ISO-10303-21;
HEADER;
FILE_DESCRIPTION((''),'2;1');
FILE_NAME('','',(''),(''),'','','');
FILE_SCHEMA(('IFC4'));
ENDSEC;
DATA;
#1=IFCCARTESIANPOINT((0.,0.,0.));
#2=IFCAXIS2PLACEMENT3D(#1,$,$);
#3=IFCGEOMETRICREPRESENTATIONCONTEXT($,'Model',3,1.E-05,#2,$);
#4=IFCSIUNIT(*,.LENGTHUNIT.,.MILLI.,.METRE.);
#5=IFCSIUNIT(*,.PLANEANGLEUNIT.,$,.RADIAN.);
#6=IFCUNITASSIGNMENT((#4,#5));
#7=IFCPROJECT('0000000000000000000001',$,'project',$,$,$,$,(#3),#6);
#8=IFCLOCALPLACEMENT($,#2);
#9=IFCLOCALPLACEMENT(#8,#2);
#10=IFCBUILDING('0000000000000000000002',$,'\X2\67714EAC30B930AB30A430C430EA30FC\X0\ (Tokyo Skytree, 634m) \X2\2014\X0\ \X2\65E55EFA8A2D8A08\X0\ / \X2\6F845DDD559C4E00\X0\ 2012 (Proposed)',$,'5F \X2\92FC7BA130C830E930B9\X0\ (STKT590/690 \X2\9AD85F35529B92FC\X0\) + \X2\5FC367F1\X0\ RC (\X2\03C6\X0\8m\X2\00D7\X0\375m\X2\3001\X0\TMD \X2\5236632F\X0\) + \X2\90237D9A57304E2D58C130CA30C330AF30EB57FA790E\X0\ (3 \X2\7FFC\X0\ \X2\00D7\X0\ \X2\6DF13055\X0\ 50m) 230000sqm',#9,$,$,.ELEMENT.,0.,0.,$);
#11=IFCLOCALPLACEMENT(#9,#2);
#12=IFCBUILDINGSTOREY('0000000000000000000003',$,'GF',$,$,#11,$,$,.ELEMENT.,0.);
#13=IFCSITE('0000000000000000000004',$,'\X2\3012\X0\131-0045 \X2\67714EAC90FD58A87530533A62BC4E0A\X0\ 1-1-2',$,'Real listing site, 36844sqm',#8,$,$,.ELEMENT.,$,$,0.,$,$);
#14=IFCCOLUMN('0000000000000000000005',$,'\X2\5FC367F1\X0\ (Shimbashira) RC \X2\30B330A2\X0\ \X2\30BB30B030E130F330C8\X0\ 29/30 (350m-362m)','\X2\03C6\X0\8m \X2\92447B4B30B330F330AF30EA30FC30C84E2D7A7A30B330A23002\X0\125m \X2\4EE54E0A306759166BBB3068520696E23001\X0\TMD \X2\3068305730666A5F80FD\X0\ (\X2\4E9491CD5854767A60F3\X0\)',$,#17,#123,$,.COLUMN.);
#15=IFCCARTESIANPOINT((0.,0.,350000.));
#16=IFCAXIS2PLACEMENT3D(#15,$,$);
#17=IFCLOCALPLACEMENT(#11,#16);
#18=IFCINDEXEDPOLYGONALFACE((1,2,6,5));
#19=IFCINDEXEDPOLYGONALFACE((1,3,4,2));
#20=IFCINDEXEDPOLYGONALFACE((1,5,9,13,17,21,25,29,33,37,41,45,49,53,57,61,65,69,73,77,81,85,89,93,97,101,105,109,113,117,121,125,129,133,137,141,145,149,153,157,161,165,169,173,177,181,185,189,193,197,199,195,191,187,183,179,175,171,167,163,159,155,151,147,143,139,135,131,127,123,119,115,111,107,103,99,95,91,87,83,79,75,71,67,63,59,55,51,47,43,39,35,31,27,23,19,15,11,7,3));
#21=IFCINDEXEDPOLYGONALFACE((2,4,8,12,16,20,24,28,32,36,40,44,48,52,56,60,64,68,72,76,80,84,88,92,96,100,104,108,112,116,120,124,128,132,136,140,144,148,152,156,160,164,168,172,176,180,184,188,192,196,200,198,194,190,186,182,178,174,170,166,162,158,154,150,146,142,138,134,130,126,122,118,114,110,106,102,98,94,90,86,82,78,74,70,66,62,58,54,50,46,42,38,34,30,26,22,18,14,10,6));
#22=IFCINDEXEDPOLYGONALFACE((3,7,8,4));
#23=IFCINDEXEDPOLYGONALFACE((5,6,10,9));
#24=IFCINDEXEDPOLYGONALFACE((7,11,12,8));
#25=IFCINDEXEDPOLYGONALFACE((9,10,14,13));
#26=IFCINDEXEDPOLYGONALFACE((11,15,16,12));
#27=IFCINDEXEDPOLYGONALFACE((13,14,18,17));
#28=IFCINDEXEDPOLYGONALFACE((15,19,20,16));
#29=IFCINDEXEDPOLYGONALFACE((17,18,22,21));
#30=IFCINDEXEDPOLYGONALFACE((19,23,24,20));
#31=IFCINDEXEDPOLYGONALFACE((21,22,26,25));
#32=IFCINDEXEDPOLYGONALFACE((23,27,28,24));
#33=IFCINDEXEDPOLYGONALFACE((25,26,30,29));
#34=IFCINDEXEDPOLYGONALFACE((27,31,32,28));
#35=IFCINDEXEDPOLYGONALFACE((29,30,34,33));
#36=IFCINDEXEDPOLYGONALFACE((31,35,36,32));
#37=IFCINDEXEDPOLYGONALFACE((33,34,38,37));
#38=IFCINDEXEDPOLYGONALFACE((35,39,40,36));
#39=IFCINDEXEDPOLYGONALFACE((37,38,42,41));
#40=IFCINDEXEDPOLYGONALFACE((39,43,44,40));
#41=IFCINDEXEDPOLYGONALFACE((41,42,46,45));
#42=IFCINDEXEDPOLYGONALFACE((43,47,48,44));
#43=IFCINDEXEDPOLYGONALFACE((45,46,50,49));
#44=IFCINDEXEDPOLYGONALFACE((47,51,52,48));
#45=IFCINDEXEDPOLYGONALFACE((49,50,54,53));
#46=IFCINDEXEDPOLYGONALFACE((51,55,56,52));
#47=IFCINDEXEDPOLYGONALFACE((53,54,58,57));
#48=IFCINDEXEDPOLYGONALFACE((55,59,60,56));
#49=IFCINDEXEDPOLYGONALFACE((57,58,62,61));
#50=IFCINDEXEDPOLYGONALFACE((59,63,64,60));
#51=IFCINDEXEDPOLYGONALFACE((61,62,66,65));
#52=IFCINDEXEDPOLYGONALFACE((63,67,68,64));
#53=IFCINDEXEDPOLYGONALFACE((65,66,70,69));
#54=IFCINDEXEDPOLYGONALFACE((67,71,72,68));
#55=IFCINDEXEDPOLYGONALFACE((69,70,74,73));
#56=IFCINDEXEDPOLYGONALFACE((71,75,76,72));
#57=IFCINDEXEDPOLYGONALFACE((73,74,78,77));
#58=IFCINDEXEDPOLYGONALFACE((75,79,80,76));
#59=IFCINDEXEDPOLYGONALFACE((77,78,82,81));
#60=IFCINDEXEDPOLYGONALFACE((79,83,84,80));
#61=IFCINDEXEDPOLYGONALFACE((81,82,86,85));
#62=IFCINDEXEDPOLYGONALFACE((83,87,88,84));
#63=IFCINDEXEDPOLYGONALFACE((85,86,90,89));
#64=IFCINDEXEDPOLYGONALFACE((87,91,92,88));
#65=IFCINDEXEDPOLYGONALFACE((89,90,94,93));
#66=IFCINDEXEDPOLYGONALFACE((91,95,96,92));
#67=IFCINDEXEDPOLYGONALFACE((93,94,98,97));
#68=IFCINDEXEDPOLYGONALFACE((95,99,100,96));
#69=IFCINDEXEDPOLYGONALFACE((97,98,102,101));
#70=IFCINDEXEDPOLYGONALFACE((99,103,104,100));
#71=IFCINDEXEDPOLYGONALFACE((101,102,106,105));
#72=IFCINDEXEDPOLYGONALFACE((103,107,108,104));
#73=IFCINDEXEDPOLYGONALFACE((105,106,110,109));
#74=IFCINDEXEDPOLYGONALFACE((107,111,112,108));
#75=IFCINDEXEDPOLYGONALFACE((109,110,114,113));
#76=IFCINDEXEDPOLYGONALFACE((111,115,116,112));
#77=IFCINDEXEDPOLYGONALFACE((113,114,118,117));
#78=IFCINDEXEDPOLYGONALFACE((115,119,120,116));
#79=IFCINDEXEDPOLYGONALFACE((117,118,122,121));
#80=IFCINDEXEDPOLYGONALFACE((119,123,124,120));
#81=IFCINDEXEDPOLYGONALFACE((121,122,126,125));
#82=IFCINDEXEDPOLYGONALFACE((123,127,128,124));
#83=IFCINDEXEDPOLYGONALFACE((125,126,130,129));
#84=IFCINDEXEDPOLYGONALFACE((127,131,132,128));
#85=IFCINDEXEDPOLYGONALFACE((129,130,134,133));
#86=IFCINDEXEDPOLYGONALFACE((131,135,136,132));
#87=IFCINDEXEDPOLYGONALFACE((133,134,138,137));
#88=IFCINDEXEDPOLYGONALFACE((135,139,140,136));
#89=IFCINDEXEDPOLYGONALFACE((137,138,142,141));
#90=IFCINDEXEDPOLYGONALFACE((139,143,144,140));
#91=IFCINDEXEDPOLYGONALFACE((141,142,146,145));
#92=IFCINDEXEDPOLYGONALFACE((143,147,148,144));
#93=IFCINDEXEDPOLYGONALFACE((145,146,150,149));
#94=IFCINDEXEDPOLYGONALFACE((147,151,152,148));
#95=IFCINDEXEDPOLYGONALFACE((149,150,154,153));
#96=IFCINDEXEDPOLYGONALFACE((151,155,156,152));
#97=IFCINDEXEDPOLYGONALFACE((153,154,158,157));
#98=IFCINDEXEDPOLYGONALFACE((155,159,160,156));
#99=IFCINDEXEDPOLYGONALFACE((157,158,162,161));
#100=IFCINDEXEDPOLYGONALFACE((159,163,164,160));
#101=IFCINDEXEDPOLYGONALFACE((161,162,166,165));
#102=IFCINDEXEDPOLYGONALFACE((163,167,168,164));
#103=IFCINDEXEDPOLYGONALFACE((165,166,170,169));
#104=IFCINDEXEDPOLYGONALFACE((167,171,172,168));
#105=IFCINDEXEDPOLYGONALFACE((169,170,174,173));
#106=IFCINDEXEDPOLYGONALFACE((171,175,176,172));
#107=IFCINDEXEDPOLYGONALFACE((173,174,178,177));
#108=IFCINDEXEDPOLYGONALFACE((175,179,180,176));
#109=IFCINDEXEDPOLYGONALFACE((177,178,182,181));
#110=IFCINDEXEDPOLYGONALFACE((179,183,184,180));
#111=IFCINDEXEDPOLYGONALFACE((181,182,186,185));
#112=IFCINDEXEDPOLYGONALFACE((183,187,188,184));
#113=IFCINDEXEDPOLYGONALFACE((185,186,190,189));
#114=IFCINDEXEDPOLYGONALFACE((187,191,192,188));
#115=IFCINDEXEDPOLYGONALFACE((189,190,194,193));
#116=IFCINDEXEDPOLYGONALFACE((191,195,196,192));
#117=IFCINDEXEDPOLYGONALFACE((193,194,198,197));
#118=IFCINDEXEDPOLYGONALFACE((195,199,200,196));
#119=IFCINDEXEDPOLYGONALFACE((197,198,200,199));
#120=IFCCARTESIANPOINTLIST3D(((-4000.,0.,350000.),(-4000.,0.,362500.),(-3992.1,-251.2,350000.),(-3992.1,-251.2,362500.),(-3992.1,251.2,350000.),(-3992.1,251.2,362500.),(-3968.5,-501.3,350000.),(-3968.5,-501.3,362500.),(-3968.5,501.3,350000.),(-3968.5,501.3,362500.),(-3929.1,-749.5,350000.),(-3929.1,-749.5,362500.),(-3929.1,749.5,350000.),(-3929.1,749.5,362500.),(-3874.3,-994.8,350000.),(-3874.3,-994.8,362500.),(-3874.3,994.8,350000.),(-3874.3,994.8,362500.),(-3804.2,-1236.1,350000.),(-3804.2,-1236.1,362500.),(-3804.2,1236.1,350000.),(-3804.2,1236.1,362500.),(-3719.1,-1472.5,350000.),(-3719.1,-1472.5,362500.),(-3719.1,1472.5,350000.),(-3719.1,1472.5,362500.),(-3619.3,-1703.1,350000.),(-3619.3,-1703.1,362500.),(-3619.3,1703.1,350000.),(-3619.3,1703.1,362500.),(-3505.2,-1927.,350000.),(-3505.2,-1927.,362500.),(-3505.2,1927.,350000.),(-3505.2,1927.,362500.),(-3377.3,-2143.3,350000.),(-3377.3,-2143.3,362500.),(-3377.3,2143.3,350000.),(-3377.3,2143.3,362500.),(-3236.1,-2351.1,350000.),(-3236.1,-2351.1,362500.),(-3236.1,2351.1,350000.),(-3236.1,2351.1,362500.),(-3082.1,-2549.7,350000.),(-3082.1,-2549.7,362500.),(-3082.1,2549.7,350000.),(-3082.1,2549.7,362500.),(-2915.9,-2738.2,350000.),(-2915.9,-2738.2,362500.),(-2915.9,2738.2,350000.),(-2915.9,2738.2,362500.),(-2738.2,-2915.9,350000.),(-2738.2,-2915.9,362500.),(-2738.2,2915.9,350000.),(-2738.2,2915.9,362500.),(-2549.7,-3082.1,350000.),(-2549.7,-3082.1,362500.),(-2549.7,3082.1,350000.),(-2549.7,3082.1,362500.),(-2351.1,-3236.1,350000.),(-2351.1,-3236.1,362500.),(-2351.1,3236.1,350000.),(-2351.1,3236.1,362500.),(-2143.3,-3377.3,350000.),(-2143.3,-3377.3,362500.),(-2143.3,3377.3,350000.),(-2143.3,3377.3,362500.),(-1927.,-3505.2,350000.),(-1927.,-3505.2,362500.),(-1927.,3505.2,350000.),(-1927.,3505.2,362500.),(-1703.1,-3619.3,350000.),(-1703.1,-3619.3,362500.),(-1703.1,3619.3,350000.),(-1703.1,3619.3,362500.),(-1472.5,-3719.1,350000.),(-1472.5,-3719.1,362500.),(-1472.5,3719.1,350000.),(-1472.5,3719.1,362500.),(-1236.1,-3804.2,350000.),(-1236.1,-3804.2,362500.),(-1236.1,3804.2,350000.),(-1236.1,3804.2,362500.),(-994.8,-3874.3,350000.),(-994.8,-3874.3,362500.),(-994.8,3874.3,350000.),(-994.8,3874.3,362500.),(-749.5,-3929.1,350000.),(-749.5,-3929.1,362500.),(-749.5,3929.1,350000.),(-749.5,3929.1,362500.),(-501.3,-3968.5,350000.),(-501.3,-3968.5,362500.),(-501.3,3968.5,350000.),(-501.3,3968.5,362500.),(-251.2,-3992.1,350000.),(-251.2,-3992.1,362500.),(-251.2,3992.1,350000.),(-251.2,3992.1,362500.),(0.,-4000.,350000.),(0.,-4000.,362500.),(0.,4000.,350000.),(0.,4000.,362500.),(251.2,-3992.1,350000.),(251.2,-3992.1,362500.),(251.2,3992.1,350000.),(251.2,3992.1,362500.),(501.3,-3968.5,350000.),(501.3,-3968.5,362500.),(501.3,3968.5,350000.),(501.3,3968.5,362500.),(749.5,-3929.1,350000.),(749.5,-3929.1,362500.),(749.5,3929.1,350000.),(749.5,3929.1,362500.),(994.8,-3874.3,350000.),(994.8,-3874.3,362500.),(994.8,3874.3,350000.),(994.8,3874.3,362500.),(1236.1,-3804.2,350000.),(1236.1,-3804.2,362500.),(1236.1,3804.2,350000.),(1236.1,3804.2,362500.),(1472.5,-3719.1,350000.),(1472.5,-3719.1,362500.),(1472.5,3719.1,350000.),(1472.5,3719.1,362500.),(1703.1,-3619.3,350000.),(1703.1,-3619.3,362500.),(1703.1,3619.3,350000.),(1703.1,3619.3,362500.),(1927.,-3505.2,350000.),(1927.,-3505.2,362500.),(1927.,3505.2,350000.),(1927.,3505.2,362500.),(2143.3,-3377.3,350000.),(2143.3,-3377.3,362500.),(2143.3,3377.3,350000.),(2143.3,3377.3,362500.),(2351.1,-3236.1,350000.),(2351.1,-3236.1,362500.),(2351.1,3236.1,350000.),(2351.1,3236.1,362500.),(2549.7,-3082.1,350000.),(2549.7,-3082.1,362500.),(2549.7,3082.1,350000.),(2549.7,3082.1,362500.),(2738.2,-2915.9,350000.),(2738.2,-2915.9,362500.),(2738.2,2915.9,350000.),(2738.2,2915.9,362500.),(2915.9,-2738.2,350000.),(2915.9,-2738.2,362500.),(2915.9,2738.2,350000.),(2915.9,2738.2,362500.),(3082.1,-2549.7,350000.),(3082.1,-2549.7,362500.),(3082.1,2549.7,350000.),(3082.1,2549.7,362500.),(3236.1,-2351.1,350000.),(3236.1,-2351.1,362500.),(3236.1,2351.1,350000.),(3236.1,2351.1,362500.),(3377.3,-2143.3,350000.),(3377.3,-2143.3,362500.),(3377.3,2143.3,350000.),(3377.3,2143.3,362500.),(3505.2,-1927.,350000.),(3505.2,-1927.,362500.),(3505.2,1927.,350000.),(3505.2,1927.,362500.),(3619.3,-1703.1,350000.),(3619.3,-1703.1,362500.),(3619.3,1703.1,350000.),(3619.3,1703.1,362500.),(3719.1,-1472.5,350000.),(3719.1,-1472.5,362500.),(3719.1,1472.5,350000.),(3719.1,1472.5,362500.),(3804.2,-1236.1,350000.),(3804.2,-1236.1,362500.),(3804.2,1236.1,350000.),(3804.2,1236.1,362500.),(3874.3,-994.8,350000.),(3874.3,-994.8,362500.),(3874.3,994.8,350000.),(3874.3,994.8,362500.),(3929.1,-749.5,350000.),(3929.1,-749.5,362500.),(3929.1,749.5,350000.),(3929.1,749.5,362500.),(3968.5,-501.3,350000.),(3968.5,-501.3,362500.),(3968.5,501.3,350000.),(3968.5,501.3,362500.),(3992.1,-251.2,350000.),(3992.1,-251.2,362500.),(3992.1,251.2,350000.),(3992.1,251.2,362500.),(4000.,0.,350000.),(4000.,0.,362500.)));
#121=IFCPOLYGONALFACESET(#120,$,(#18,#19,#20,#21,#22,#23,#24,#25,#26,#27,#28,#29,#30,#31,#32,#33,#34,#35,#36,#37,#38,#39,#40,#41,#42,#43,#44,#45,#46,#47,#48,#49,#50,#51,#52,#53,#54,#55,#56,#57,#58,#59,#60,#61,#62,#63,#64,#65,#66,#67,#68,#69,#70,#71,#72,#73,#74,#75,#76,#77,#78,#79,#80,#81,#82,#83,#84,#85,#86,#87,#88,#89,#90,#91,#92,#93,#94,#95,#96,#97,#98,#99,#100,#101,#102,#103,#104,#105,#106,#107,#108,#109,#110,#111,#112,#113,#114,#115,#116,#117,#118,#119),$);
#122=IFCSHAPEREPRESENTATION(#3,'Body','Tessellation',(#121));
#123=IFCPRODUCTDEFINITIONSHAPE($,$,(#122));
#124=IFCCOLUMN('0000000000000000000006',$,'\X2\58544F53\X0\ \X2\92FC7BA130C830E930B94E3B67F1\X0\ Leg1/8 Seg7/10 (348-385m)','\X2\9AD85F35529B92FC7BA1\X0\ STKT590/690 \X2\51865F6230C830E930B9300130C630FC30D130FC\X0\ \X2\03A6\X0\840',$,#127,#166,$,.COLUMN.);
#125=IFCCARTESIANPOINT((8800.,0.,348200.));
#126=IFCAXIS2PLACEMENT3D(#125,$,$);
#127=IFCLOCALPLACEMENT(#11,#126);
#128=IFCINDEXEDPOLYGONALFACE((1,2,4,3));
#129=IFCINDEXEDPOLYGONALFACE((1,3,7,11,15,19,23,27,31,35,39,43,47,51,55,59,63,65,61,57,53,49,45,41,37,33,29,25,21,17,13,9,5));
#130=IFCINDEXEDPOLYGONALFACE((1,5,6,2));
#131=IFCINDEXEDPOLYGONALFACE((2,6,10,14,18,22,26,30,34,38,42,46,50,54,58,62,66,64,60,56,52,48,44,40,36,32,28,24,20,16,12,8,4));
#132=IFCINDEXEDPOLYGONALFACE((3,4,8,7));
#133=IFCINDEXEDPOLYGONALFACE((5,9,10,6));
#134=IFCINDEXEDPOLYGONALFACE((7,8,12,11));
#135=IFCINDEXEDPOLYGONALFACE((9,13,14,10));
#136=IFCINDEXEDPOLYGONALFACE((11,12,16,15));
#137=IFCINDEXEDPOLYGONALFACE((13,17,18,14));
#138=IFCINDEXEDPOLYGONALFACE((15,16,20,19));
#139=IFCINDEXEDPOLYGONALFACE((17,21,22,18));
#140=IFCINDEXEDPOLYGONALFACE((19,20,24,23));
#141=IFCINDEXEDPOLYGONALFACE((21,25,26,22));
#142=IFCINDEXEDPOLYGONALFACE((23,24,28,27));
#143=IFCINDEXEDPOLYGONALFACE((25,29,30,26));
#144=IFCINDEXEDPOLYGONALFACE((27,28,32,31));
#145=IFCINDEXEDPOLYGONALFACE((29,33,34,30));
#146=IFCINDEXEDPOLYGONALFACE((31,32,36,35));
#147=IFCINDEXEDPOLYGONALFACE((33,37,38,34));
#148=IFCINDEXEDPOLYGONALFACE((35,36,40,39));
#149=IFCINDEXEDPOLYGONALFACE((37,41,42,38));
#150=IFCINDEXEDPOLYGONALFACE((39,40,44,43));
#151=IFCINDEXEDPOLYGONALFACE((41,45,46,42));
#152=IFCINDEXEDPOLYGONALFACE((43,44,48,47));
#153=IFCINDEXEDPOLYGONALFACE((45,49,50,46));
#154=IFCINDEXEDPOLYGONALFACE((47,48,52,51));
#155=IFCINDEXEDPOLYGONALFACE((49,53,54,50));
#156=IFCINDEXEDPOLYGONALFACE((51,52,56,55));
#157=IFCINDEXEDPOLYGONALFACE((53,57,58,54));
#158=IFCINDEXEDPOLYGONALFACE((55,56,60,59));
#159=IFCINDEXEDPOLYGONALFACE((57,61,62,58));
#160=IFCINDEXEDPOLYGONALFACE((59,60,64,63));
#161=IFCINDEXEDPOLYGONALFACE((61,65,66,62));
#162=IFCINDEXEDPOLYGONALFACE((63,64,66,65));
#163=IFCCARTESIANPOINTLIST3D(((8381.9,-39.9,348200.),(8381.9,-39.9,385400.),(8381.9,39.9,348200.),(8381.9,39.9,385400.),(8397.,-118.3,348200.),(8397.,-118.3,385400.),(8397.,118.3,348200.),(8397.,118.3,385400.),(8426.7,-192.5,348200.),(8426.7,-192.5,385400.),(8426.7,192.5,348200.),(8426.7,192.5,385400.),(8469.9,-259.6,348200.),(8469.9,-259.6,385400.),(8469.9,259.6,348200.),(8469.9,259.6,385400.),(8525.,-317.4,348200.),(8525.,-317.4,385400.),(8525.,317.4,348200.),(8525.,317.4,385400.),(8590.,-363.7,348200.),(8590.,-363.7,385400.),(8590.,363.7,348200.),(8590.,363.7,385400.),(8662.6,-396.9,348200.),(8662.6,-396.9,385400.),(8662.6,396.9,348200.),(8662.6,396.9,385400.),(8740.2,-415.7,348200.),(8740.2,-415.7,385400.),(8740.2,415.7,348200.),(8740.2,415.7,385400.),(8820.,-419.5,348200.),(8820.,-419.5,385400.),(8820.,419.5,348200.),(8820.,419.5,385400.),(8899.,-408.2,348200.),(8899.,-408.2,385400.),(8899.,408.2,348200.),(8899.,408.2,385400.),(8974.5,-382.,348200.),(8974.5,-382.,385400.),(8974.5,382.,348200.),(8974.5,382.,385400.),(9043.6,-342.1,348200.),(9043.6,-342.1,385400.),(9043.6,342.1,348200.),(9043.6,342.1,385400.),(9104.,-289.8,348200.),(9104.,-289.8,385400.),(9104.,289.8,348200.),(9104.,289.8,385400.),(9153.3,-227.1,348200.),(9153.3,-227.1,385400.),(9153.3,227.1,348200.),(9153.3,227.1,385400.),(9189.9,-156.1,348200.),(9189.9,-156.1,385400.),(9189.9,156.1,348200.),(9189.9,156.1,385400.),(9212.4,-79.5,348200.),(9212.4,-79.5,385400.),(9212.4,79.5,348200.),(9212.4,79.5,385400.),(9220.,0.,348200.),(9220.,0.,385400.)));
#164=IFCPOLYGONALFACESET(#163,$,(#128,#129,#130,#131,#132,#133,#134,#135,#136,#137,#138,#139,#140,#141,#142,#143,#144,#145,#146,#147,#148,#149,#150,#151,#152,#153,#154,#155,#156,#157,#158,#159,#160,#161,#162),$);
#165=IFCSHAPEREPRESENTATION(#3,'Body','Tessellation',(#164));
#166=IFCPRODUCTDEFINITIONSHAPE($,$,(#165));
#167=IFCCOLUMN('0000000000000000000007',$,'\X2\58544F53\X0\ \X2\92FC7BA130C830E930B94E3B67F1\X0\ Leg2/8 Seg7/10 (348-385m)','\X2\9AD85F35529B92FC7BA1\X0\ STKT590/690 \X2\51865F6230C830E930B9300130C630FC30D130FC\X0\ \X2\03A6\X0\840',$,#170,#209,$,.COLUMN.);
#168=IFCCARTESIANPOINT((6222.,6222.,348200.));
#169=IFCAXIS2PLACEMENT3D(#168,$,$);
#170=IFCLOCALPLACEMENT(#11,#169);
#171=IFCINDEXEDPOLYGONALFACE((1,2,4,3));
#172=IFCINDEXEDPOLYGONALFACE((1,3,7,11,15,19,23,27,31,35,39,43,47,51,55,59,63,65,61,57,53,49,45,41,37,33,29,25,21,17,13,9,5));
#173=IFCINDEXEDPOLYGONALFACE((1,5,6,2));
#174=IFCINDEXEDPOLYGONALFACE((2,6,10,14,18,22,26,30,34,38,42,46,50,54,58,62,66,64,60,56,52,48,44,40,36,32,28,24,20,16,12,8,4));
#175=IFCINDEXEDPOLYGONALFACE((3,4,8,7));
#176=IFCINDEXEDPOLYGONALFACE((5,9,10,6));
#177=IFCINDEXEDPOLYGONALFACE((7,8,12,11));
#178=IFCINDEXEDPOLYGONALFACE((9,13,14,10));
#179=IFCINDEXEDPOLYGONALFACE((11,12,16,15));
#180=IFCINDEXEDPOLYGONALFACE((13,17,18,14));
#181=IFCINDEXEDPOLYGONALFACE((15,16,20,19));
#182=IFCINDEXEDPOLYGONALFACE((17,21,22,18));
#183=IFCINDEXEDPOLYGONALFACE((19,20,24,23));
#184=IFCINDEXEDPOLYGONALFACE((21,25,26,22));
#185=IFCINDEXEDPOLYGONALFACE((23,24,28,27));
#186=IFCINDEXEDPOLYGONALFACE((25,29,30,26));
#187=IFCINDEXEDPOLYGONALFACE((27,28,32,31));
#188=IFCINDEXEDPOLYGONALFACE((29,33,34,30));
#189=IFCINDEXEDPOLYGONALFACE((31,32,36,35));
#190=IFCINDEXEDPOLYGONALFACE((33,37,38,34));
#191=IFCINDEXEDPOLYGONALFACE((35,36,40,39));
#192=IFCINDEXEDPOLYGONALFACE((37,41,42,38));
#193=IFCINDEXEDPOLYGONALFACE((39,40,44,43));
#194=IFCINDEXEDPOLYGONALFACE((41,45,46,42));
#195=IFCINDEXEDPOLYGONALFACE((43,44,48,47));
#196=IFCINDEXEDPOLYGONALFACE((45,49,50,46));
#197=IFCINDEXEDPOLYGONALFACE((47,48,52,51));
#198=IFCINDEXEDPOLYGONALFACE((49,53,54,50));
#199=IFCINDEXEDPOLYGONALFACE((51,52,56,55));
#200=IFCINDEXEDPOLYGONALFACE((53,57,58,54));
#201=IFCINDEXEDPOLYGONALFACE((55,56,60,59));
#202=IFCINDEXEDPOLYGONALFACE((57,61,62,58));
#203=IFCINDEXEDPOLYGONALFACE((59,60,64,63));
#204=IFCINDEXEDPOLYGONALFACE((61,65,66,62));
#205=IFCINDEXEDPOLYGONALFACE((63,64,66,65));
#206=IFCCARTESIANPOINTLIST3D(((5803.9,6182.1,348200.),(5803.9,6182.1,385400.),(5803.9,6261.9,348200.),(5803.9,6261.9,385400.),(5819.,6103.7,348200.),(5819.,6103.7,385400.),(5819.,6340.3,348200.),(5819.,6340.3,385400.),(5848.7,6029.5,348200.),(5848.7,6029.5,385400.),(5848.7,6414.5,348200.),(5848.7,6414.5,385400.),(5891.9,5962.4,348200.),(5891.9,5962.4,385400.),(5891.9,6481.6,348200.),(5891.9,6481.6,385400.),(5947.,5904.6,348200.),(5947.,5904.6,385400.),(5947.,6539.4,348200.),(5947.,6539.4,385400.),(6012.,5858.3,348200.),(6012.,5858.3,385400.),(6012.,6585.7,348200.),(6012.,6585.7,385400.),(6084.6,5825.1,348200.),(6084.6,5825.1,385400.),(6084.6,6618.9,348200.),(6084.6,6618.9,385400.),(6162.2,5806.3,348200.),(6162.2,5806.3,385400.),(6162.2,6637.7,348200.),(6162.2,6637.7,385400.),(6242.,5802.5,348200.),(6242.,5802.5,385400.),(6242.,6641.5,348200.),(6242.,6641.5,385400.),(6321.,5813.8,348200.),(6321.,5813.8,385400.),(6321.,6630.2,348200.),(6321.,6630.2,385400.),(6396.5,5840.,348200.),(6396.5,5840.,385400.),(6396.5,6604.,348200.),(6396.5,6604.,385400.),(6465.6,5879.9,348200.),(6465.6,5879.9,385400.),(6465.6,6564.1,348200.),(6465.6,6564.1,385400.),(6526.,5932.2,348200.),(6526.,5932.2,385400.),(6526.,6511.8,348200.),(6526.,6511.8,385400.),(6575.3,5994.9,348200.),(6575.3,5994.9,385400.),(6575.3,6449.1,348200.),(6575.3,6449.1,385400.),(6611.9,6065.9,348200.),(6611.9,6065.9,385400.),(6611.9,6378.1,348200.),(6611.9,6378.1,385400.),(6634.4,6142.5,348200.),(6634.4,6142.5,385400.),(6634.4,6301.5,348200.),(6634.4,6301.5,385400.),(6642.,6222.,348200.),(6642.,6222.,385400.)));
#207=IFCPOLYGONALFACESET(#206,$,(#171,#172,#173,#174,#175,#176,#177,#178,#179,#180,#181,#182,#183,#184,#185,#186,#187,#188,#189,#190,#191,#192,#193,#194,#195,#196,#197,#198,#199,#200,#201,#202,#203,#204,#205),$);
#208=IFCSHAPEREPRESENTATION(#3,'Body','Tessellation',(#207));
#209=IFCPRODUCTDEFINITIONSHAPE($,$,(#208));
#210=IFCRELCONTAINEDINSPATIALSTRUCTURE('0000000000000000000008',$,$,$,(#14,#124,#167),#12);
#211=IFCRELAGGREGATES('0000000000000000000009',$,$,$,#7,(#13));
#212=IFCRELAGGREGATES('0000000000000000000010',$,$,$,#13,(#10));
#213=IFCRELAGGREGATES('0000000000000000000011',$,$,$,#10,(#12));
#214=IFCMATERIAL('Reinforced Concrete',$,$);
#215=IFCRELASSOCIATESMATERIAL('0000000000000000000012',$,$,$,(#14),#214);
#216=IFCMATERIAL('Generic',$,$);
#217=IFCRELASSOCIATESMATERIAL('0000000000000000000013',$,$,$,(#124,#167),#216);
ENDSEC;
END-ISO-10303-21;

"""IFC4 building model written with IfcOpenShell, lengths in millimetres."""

from ifc_helpers import new_model, si_unit, frame, origin, origin_2d, place, context, project, spatial, circle, extrude, material, element, save


model = new_model("IFC4")

# Units and contexts
model_context = context("Model", 3, precision=1e-05, world=origin())
ifc_project = project(units=[si_unit("LENGTHUNIT", "METRE", prefix="MILLI"), si_unit("PLANEANGLEUNIT", "RADIAN")], contexts=[model_context])

# Site, building, storey
site_placement = place(None, origin())
site = spatial("IfcSite", under=ifc_project, at=site_placement, Name="〒131-0045 東京都墨田区押上 1-1-2", ObjectType="Real listing site, 36844sqm", CompositionType="ELEMENT", RefElevation=0.0)
building_placement = place(site_placement, origin())
building = spatial("IfcBuilding", under=site, at=building_placement, Name="東京スカイツリー (Tokyo Skytree, 634m) — 日建設計 / 澄川喜一 2012 (Proposed)", ObjectType="5F 鋼管トラス (STKT590/690 高張力鋼) + 心柱 RC (φ8m×375m、TMD 制振) + 連続地中壁ナックル基礎 (3 翼 × 深さ 50m) 230000sqm", CompositionType="ELEMENT", ElevationOfRefHeight=0.0, ElevationOfTerrain=0.0)
storey_placement = place(building_placement, origin())
storey = spatial("IfcBuildingStorey", under=building, at=storey_placement, Name="GF", CompositionType="ELEMENT", Elevation=0.0)

# Columns
ifc_material_1 = material(Name="Reinforced Concrete")
column_1_placement = place(storey_placement, frame((0.0, 0.0, 350000.0)))
element("IfcColumn", 1, at=column_1_placement, inside=storey, material=ifc_material_1, Name="心柱 (Shimbashira) RC コア セグメント 29/30 (350m-362m)", Description="φ8m 鉄筋コンクリート中空コア。125m 以上で外殻と分離、TMD として機能 (五重塔発想)", PredefinedType="COLUMN", context=model_context, shape_type="SweptSolid", body=[
    extrude(circle(Radius=4000.0, at=origin_2d()), frame((0.0, 0.0, 350000.0)), (0.0, 0.0, 1.0), 12500.0),
])
ifc_material_2 = material(Name="Generic")
column_2_placement = place(storey_placement, frame((8800.0, 0.0, 348200.0)))
element("IfcColumn", 2, at=column_2_placement, inside=storey, material=ifc_material_2, Name="塔体 鋼管トラス主柱 Leg1/8 Seg7/10 (348-385m)", Description="高張力鋼管 STKT590/690 円形トラス、テーパー Φ840", PredefinedType="COLUMN", context=model_context, shape_type="SweptSolid", body=[
    extrude(circle(Radius=420.0, at=origin_2d()), frame((8800.0, 0.0, 348200.0)), (0.0, 0.0, 1.0), 37200.0),
])
column_3_placement = place(storey_placement, frame((6222.0, 6222.0, 348200.0)))
element("IfcColumn", 3, at=column_3_placement, inside=storey, material=ifc_material_2, Name="塔体 鋼管トラス主柱 Leg2/8 Seg7/10 (348-385m)", Description="高張力鋼管 STKT590/690 円形トラス、テーパー Φ840", PredefinedType="COLUMN", context=model_context, shape_type="SweptSolid", body=[
    extrude(circle(Radius=420.0, at=origin_2d()), frame((6222.0, 6222.0, 348200.0)), (0.0, 0.0, 1.0), 37200.0),
])

save(model, "model.ifc")
